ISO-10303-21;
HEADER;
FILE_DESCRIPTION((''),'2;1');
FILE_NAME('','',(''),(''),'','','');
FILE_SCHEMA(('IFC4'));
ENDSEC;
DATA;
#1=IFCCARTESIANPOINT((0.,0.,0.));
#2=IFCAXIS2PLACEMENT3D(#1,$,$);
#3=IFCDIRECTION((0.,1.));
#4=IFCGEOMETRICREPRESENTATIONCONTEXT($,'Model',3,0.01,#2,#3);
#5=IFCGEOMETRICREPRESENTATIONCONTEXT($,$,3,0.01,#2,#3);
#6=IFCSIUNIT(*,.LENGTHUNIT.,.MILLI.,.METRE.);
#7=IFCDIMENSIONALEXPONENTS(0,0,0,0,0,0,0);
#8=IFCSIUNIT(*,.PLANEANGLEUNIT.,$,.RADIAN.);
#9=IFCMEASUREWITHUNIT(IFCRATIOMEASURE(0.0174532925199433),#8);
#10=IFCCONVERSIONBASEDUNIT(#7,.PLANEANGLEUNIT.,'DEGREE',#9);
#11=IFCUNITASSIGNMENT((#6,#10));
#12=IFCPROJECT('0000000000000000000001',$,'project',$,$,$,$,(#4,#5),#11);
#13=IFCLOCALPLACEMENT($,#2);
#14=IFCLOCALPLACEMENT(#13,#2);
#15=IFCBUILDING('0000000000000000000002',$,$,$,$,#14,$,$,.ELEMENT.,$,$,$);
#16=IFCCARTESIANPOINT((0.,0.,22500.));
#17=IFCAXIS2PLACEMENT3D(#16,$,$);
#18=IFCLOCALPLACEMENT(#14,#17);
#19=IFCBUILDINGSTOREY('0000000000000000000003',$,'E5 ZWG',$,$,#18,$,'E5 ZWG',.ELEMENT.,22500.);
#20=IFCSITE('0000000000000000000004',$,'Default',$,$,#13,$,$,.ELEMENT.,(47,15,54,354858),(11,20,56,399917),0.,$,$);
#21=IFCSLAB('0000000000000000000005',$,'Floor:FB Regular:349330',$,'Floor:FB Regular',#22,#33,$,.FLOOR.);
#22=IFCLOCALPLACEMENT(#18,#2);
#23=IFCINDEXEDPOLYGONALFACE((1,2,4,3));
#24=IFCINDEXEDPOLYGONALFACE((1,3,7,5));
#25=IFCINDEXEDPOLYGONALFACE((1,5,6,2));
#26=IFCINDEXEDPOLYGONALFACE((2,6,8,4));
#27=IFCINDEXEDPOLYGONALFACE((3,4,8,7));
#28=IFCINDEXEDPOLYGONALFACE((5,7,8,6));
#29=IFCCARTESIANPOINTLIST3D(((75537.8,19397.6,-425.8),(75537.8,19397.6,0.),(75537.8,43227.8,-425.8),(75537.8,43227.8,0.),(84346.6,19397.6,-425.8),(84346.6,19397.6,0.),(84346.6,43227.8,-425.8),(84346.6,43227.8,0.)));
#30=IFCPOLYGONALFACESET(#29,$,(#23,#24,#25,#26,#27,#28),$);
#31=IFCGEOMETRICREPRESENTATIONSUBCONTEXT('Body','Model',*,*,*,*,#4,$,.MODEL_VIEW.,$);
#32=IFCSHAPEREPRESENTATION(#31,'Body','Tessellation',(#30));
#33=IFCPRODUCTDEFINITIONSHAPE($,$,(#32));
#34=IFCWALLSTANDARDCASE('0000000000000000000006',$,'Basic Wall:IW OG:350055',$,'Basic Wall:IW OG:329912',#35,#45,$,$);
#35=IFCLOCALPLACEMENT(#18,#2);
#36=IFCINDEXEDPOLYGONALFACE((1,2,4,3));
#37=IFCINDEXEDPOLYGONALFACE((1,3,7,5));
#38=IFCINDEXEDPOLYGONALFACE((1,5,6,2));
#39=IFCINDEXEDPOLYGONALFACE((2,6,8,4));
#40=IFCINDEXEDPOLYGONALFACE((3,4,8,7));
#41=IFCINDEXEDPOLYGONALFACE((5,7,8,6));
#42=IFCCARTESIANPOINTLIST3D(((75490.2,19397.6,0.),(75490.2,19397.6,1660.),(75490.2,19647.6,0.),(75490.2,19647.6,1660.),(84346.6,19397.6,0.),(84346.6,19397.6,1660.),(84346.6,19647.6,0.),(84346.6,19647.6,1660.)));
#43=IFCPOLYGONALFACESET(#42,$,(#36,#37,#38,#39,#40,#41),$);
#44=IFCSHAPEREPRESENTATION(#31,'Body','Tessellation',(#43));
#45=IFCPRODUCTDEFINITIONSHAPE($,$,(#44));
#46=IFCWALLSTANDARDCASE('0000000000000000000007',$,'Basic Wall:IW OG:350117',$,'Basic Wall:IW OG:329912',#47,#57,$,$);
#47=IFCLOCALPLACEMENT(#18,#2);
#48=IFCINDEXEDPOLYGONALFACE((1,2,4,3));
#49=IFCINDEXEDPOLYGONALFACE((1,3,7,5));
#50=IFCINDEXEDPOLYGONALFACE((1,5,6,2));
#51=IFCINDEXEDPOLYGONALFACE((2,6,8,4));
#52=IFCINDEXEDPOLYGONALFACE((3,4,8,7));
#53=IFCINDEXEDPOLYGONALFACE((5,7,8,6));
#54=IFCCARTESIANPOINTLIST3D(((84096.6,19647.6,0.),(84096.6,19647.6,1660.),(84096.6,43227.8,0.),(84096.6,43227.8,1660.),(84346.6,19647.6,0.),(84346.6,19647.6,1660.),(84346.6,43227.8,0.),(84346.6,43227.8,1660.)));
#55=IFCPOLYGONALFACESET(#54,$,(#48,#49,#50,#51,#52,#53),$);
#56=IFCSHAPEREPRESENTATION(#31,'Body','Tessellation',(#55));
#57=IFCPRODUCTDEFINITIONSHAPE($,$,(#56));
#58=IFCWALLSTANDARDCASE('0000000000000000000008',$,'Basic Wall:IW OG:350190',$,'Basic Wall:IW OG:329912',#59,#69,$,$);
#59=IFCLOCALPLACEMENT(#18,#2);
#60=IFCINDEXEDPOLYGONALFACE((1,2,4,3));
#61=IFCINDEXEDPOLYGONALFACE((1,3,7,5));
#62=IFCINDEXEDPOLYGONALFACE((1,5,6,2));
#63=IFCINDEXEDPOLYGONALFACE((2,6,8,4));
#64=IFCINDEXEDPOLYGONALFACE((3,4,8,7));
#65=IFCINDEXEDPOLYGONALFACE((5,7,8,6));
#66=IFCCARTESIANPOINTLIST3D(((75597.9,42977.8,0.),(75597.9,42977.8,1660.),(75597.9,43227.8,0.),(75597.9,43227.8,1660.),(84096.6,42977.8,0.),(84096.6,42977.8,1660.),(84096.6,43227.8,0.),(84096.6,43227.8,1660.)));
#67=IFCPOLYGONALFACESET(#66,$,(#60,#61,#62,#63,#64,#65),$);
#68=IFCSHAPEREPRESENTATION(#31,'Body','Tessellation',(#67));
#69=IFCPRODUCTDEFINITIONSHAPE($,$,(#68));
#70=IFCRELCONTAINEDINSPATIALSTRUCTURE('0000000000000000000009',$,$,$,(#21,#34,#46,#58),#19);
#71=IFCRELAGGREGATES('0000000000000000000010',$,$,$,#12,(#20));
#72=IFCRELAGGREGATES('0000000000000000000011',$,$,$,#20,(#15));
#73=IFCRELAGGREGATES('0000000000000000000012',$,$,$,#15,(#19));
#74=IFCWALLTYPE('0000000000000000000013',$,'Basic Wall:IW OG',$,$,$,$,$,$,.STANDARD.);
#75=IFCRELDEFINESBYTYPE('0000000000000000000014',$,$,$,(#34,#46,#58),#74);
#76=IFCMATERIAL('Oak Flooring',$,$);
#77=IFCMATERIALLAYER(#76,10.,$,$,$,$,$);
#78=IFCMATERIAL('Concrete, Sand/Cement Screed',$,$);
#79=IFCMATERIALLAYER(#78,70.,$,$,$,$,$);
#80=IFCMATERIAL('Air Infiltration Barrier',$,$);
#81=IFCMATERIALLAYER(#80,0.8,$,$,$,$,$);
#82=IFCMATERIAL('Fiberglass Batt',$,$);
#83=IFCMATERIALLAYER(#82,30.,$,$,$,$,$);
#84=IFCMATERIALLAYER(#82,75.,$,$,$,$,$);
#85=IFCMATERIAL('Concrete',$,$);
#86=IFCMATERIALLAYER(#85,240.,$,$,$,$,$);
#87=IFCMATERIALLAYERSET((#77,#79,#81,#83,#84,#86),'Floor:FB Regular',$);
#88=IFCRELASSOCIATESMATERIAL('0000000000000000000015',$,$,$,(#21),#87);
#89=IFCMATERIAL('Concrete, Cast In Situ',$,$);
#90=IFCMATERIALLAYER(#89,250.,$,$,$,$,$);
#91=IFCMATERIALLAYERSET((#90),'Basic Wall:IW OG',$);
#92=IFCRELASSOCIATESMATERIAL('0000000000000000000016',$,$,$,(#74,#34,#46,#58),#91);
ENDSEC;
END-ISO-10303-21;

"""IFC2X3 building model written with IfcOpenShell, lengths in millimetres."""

from ifc_helpers import new_model, entity, si_unit, converted_unit, direction, frame, frame_2d, origin, place, context, subcontext, project, spatial, rectangle, extrude, material, layer, layer_set, layer_usage, type_object, element, save


model = new_model("IFC2X3")

# Units and contexts
model_context = context("Model", 3, precision=0.01, world=origin(), true_north=direction((0.0, 1.0)))
context_of_model = context(None, 3, precision=0.01, world=origin(), true_north=direction((0.0, 1.0)))
body_context = subcontext(model_context, "Body", "Model", "MODEL_VIEW")
ifc_project = project(units=[si_unit("LENGTHUNIT", "METRE", prefix="MILLI"), converted_unit("PLANEANGLEUNIT", "DEGREE", entity("IfcRatioMeasure", 0.0174532925199433), si_unit("PLANEANGLEUNIT", "RADIAN"), dimensions=[0, 0, 0, 0, 0, 0, 0])], contexts=[model_context, context_of_model])

# Site, building, storey
site_placement = place(None, origin())
site = spatial("IfcSite", under=ifc_project, at=site_placement, Name="Default", CompositionType="ELEMENT", RefLatitude=(47, 15, 54, 354858), RefLongitude=(11, 20, 56, 399917), RefElevation=0.0)
building_placement = place(site_placement, origin())
building = spatial("IfcBuilding", under=site, at=building_placement, CompositionType="ELEMENT")
storey_placement = place(building_placement, frame((0.0, 0.0, 22500.0)))
storey = spatial("IfcBuildingStorey", under=building, at=storey_placement, Name="E5 ZWG", LongName="E5 ZWG", CompositionType="ELEMENT", Elevation=22500.0)

# Slab
ifc_material_1 = material(Name="Oak Flooring")
ifc_layer_1 = layer(ifc_material_1, 10.0)
ifc_material_2 = material(Name="Concrete, Sand/Cement Screed")
ifc_layer_2 = layer(ifc_material_2, 70.0)
ifc_material_3 = material(Name="Air Infiltration Barrier")
ifc_layer_3 = layer(ifc_material_3, 0.8)
ifc_material_4 = material(Name="Fiberglass Batt")
ifc_layer_4 = layer(ifc_material_4, 30.0)
ifc_layer_5 = layer(ifc_material_4, 75.0)
ifc_material_5 = material(Name="Concrete")
ifc_layer_6 = layer(ifc_material_5, 240.0)
ifc_layer_set_1 = layer_set([ifc_layer_1, ifc_layer_2, ifc_layer_3, ifc_layer_4, ifc_layer_5, ifc_layer_6], Name="Floor:FB Regular")
ifc_layer_usage_1 = layer_usage(ifc_layer_set_1, "AXIS3", "POSITIVE", 0.0)
slab_placement = place(storey_placement, origin())
element("IfcSlab", 1, at=slab_placement, inside=storey, material=ifc_layer_usage_1, Name="Floor:FB Regular:349330", ObjectType="Floor:FB Regular", PredefinedType="FLOOR", context=body_context, shape_type="SweptSolid", body=[
    extrude(rectangle(XDim=23830.1, YDim=8808.8, at=frame_2d((0.0, 0.0), x_axis=(1.0, 0.0))), frame((79942.2, 31312.7, 0.0), z_axis=(0.0, 0.0, -1.0), x_axis=(0.0, 1.0, 0.0)), (0.0, 0.0, 1.0), 425.8),
])

# Walls
ifc_material_6 = material(Name="Concrete, Cast In Situ")
ifc_layer_7 = layer(ifc_material_6, 250.0)
ifc_layer_set_2 = layer_set([ifc_layer_7], Name="Basic Wall:IW OG")
ifc_layer_usage_2 = layer_usage(ifc_layer_set_2, "AXIS2", "POSITIVE", -125.0)
wall_type = type_object("IfcWallType", Name="Basic Wall:IW OG", PredefinedType="STANDARD", material=ifc_layer_set_2)
wall_1_placement = place(storey_placement, frame((75490.2, 19522.6, 0.0)))
element("IfcWallStandardCase", 2, at=wall_1_placement, inside=storey, type_object=wall_type, material=ifc_layer_usage_2, Name="Basic Wall:IW OG:350055", ObjectType="Basic Wall:IW OG:329912", context=body_context, shape_type="SweptSolid", body=[
    extrude(rectangle(XDim=8856.4, YDim=250.0, at=frame_2d((4428.2, 0.0), x_axis=(-1.0, 0.0))), origin(), (0.0, 0.0, 1.0), 1660.0),
])
ifc_layer_usage_3 = layer_usage(ifc_layer_set_2, "AXIS2", "POSITIVE", -125.0)
wall_2_placement = place(storey_placement, frame((84221.6, 19647.6, 0.0), z_axis=(0.0, 0.0, 1.0), x_axis=(0.0, 1.0, 0.0)))
element("IfcWallStandardCase", 3, at=wall_2_placement, inside=storey, type_object=wall_type, material=ifc_layer_usage_3, Name="Basic Wall:IW OG:350117", ObjectType="Basic Wall:IW OG:329912", context=body_context, shape_type="SweptSolid", body=[
    extrude(rectangle(XDim=23580.1, YDim=250.0, at=frame_2d((11790.1, 0.0), x_axis=(-1.0, 0.0))), origin(), (0.0, 0.0, 1.0), 1660.0),
])
ifc_layer_usage_4 = layer_usage(ifc_layer_set_2, "AXIS2", "POSITIVE", -125.0)
wall_3_placement = place(storey_placement, frame((84096.6, 43102.8, 0.0), z_axis=(0.0, 0.0, 1.0), x_axis=(-1.0, 0.0, 0.0)))
element("IfcWallStandardCase", 4, at=wall_3_placement, inside=storey, type_object=wall_type, material=ifc_layer_usage_4, Name="Basic Wall:IW OG:350190", ObjectType="Basic Wall:IW OG:329912", context=body_context, shape_type="SweptSolid", body=[
    extrude(rectangle(XDim=8498.7, YDim=250.0, at=frame_2d((4249.4, 0.0), x_axis=(-1.0, 0.0))), origin(), (0.0, 0.0, 1.0), 1660.0),
])

save(model, "model.ifc")
